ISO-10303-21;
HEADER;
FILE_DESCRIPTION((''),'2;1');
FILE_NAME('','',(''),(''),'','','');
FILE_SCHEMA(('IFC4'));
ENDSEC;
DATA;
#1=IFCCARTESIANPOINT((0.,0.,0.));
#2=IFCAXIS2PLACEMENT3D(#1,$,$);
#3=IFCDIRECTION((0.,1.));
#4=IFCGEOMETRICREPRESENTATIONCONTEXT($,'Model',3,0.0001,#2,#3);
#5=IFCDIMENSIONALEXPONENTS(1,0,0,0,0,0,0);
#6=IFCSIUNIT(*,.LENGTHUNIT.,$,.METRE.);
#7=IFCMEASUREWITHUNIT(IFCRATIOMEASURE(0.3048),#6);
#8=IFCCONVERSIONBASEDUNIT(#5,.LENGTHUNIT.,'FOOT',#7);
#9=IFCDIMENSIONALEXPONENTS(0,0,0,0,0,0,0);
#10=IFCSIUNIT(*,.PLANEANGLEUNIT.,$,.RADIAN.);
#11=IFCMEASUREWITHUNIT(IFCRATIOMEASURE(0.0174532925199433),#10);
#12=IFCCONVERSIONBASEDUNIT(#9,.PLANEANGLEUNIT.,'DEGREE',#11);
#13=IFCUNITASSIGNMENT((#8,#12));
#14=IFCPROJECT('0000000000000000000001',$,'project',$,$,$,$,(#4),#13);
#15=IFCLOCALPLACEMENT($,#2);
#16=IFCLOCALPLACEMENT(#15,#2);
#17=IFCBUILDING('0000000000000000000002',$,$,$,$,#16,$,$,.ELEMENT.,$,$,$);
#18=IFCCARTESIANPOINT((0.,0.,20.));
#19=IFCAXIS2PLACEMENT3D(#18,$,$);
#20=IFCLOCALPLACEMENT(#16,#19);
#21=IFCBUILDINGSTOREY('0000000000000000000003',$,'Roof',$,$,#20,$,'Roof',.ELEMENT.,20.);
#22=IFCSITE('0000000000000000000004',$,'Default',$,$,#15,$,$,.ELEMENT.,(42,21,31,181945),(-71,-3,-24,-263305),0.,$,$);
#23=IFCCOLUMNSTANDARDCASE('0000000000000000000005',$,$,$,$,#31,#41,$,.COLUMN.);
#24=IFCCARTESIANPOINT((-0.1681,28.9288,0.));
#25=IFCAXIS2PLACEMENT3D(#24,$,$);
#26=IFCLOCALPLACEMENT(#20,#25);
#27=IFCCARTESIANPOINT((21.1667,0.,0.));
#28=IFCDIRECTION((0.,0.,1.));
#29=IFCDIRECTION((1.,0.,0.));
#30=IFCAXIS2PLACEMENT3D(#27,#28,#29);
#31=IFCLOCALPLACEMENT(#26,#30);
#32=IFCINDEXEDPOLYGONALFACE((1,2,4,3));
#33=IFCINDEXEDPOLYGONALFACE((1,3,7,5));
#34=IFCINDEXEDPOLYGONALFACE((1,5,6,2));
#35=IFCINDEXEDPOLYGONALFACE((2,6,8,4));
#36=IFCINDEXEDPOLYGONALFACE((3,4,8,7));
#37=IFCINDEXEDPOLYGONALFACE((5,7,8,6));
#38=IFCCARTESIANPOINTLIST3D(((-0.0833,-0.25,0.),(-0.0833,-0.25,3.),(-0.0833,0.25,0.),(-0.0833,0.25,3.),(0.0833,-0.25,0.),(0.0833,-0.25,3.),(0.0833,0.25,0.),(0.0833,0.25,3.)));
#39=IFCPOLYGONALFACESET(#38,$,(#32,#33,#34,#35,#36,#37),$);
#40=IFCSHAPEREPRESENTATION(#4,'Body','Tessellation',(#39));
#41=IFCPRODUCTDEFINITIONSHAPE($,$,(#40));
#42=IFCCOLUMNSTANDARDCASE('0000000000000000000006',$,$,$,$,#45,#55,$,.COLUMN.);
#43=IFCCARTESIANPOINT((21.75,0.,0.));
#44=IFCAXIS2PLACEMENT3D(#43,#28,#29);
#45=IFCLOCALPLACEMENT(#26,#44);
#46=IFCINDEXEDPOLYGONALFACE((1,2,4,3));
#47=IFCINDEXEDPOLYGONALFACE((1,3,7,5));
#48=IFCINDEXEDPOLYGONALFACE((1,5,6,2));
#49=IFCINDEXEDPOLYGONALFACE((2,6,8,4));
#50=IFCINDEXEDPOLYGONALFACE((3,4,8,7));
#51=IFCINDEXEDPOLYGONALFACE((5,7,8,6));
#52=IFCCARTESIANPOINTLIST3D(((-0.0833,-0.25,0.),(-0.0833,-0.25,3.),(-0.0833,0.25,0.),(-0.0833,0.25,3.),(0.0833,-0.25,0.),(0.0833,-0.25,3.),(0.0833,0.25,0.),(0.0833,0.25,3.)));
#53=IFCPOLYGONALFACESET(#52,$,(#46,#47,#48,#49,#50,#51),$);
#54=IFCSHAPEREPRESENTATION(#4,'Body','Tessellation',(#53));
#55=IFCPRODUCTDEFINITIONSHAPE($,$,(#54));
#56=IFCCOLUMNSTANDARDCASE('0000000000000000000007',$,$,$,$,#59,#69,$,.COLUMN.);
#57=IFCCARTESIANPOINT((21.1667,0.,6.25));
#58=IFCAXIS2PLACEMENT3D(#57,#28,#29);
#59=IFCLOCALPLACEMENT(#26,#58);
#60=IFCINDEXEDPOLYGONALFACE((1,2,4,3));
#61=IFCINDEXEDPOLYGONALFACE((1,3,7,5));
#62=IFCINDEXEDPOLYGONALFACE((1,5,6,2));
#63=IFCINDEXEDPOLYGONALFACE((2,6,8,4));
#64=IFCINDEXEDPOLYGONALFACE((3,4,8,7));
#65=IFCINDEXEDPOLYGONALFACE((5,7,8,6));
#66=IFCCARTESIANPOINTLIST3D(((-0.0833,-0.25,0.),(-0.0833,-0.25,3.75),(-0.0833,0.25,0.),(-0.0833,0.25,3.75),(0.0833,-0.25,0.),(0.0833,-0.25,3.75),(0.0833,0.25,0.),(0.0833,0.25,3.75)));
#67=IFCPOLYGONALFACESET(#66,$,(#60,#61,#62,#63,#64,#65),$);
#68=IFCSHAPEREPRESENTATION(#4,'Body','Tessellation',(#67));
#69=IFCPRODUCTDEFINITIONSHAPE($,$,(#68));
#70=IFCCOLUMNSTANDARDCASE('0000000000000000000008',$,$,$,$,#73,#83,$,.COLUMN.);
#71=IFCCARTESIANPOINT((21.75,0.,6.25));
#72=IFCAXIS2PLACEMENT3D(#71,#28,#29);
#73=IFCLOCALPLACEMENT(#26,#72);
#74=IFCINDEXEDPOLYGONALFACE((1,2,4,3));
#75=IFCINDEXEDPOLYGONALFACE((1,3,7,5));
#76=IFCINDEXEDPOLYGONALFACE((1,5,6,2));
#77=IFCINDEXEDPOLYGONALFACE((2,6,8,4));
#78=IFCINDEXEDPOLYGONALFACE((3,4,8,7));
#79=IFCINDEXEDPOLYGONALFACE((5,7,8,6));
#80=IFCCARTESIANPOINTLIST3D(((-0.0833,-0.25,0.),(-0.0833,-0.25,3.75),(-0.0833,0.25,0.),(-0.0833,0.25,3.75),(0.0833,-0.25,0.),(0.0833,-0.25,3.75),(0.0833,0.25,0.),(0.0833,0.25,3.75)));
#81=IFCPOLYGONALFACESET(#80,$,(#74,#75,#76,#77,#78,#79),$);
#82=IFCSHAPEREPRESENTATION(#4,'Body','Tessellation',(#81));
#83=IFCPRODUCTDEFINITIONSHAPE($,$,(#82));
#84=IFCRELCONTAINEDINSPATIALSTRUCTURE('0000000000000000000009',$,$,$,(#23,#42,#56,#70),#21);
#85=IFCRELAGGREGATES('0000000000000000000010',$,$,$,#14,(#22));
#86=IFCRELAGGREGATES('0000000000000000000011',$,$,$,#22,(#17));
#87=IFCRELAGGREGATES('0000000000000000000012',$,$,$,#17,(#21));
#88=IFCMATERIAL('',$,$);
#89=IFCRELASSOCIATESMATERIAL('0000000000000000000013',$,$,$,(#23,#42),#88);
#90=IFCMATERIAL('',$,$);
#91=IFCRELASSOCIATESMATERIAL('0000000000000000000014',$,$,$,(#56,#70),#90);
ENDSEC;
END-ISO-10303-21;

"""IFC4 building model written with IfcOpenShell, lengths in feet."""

from ifc_helpers import new_model, entity, si_unit, converted_unit, direction, frame, origin, place, context, project, spatial, rectangle, extrude, material, element, save


model = new_model("IFC4")

# Units and contexts
model_context = context("Model", 3, precision=0.0001, world=origin(), true_north=direction((0.0, 1.0)))
ifc_project = project(units=[converted_unit("LENGTHUNIT", "FOOT", entity("IfcRatioMeasure", 0.3048), si_unit("LENGTHUNIT", "METRE"), dimensions=[1, 0, 0, 0, 0, 0, 0]), converted_unit("PLANEANGLEUNIT", "DEGREE", entity("IfcRatioMeasure", 0.0174532925199433), si_unit("PLANEANGLEUNIT", "RADIAN"), dimensions=[0, 0, 0, 0, 0, 0, 0])], contexts=[model_context])

# Site, building, storey
site_placement = place(None, origin())
site = spatial("IfcSite", under=ifc_project, at=site_placement, Name="Default", CompositionType="ELEMENT", RefLatitude=(42, 21, 31, 181945), RefLongitude=(-71, -3, -24, -263305), RefElevation=0.0)
building_placement = place(site_placement, origin())
building = spatial("IfcBuilding", under=site, at=building_placement, CompositionType="ELEMENT")
storey_placement = place(building_placement, frame((0.0, 0.0, 20.0)))
storey = spatial("IfcBuildingStorey", under=building, at=storey_placement, Name="Roof", LongName="Roof", CompositionType="ELEMENT", Elevation=20.0)

# Columns
ifc_material_1 = material(Name="")
placement = place(storey_placement, frame((-0.1681, 28.9288, 0.0)))
for number, where, z_axis, x_axis in (
    (1, (21.1667, 0.0, 0.0), (0.0, 0.0, 1.0), (1.0, 0.0, 0.0)),
    (2, (21.75, 0.0, 0.0), (0.0, 0.0, 1.0), (1.0, 0.0, 0.0)),
):
    element("IfcColumnStandardCase", number, at=place(placement, frame(where, z_axis=z_axis, x_axis=x_axis)), inside=storey, material=ifc_material_1, PredefinedType="COLUMN", context=model_context, shape_type="SweptSolid", body=[
        extrude(rectangle(XDim=0.1667, YDim=0.5), origin(), (0.0, 0.0, 1.0), 3.0),
    ])
ifc_material_2 = material(Name="")
for number, where, z_axis, x_axis in (
    (3, (21.1667, 0.0, 6.25), (0.0, 0.0, 1.0), (1.0, 0.0, 0.0)),
    (4, (21.75, 0.0, 6.25), (0.0, 0.0, 1.0), (1.0, 0.0, 0.0)),
):
    element("IfcColumnStandardCase", number, at=place(placement, frame(where, z_axis=z_axis, x_axis=x_axis)), inside=storey, material=ifc_material_2, PredefinedType="COLUMN", context=model_context, shape_type="SweptSolid", body=[
        extrude(rectangle(XDim=0.1667, YDim=0.5), origin(), (0.0, 0.0, 1.0), 3.75),
    ])

save(model, "model.ifc")
